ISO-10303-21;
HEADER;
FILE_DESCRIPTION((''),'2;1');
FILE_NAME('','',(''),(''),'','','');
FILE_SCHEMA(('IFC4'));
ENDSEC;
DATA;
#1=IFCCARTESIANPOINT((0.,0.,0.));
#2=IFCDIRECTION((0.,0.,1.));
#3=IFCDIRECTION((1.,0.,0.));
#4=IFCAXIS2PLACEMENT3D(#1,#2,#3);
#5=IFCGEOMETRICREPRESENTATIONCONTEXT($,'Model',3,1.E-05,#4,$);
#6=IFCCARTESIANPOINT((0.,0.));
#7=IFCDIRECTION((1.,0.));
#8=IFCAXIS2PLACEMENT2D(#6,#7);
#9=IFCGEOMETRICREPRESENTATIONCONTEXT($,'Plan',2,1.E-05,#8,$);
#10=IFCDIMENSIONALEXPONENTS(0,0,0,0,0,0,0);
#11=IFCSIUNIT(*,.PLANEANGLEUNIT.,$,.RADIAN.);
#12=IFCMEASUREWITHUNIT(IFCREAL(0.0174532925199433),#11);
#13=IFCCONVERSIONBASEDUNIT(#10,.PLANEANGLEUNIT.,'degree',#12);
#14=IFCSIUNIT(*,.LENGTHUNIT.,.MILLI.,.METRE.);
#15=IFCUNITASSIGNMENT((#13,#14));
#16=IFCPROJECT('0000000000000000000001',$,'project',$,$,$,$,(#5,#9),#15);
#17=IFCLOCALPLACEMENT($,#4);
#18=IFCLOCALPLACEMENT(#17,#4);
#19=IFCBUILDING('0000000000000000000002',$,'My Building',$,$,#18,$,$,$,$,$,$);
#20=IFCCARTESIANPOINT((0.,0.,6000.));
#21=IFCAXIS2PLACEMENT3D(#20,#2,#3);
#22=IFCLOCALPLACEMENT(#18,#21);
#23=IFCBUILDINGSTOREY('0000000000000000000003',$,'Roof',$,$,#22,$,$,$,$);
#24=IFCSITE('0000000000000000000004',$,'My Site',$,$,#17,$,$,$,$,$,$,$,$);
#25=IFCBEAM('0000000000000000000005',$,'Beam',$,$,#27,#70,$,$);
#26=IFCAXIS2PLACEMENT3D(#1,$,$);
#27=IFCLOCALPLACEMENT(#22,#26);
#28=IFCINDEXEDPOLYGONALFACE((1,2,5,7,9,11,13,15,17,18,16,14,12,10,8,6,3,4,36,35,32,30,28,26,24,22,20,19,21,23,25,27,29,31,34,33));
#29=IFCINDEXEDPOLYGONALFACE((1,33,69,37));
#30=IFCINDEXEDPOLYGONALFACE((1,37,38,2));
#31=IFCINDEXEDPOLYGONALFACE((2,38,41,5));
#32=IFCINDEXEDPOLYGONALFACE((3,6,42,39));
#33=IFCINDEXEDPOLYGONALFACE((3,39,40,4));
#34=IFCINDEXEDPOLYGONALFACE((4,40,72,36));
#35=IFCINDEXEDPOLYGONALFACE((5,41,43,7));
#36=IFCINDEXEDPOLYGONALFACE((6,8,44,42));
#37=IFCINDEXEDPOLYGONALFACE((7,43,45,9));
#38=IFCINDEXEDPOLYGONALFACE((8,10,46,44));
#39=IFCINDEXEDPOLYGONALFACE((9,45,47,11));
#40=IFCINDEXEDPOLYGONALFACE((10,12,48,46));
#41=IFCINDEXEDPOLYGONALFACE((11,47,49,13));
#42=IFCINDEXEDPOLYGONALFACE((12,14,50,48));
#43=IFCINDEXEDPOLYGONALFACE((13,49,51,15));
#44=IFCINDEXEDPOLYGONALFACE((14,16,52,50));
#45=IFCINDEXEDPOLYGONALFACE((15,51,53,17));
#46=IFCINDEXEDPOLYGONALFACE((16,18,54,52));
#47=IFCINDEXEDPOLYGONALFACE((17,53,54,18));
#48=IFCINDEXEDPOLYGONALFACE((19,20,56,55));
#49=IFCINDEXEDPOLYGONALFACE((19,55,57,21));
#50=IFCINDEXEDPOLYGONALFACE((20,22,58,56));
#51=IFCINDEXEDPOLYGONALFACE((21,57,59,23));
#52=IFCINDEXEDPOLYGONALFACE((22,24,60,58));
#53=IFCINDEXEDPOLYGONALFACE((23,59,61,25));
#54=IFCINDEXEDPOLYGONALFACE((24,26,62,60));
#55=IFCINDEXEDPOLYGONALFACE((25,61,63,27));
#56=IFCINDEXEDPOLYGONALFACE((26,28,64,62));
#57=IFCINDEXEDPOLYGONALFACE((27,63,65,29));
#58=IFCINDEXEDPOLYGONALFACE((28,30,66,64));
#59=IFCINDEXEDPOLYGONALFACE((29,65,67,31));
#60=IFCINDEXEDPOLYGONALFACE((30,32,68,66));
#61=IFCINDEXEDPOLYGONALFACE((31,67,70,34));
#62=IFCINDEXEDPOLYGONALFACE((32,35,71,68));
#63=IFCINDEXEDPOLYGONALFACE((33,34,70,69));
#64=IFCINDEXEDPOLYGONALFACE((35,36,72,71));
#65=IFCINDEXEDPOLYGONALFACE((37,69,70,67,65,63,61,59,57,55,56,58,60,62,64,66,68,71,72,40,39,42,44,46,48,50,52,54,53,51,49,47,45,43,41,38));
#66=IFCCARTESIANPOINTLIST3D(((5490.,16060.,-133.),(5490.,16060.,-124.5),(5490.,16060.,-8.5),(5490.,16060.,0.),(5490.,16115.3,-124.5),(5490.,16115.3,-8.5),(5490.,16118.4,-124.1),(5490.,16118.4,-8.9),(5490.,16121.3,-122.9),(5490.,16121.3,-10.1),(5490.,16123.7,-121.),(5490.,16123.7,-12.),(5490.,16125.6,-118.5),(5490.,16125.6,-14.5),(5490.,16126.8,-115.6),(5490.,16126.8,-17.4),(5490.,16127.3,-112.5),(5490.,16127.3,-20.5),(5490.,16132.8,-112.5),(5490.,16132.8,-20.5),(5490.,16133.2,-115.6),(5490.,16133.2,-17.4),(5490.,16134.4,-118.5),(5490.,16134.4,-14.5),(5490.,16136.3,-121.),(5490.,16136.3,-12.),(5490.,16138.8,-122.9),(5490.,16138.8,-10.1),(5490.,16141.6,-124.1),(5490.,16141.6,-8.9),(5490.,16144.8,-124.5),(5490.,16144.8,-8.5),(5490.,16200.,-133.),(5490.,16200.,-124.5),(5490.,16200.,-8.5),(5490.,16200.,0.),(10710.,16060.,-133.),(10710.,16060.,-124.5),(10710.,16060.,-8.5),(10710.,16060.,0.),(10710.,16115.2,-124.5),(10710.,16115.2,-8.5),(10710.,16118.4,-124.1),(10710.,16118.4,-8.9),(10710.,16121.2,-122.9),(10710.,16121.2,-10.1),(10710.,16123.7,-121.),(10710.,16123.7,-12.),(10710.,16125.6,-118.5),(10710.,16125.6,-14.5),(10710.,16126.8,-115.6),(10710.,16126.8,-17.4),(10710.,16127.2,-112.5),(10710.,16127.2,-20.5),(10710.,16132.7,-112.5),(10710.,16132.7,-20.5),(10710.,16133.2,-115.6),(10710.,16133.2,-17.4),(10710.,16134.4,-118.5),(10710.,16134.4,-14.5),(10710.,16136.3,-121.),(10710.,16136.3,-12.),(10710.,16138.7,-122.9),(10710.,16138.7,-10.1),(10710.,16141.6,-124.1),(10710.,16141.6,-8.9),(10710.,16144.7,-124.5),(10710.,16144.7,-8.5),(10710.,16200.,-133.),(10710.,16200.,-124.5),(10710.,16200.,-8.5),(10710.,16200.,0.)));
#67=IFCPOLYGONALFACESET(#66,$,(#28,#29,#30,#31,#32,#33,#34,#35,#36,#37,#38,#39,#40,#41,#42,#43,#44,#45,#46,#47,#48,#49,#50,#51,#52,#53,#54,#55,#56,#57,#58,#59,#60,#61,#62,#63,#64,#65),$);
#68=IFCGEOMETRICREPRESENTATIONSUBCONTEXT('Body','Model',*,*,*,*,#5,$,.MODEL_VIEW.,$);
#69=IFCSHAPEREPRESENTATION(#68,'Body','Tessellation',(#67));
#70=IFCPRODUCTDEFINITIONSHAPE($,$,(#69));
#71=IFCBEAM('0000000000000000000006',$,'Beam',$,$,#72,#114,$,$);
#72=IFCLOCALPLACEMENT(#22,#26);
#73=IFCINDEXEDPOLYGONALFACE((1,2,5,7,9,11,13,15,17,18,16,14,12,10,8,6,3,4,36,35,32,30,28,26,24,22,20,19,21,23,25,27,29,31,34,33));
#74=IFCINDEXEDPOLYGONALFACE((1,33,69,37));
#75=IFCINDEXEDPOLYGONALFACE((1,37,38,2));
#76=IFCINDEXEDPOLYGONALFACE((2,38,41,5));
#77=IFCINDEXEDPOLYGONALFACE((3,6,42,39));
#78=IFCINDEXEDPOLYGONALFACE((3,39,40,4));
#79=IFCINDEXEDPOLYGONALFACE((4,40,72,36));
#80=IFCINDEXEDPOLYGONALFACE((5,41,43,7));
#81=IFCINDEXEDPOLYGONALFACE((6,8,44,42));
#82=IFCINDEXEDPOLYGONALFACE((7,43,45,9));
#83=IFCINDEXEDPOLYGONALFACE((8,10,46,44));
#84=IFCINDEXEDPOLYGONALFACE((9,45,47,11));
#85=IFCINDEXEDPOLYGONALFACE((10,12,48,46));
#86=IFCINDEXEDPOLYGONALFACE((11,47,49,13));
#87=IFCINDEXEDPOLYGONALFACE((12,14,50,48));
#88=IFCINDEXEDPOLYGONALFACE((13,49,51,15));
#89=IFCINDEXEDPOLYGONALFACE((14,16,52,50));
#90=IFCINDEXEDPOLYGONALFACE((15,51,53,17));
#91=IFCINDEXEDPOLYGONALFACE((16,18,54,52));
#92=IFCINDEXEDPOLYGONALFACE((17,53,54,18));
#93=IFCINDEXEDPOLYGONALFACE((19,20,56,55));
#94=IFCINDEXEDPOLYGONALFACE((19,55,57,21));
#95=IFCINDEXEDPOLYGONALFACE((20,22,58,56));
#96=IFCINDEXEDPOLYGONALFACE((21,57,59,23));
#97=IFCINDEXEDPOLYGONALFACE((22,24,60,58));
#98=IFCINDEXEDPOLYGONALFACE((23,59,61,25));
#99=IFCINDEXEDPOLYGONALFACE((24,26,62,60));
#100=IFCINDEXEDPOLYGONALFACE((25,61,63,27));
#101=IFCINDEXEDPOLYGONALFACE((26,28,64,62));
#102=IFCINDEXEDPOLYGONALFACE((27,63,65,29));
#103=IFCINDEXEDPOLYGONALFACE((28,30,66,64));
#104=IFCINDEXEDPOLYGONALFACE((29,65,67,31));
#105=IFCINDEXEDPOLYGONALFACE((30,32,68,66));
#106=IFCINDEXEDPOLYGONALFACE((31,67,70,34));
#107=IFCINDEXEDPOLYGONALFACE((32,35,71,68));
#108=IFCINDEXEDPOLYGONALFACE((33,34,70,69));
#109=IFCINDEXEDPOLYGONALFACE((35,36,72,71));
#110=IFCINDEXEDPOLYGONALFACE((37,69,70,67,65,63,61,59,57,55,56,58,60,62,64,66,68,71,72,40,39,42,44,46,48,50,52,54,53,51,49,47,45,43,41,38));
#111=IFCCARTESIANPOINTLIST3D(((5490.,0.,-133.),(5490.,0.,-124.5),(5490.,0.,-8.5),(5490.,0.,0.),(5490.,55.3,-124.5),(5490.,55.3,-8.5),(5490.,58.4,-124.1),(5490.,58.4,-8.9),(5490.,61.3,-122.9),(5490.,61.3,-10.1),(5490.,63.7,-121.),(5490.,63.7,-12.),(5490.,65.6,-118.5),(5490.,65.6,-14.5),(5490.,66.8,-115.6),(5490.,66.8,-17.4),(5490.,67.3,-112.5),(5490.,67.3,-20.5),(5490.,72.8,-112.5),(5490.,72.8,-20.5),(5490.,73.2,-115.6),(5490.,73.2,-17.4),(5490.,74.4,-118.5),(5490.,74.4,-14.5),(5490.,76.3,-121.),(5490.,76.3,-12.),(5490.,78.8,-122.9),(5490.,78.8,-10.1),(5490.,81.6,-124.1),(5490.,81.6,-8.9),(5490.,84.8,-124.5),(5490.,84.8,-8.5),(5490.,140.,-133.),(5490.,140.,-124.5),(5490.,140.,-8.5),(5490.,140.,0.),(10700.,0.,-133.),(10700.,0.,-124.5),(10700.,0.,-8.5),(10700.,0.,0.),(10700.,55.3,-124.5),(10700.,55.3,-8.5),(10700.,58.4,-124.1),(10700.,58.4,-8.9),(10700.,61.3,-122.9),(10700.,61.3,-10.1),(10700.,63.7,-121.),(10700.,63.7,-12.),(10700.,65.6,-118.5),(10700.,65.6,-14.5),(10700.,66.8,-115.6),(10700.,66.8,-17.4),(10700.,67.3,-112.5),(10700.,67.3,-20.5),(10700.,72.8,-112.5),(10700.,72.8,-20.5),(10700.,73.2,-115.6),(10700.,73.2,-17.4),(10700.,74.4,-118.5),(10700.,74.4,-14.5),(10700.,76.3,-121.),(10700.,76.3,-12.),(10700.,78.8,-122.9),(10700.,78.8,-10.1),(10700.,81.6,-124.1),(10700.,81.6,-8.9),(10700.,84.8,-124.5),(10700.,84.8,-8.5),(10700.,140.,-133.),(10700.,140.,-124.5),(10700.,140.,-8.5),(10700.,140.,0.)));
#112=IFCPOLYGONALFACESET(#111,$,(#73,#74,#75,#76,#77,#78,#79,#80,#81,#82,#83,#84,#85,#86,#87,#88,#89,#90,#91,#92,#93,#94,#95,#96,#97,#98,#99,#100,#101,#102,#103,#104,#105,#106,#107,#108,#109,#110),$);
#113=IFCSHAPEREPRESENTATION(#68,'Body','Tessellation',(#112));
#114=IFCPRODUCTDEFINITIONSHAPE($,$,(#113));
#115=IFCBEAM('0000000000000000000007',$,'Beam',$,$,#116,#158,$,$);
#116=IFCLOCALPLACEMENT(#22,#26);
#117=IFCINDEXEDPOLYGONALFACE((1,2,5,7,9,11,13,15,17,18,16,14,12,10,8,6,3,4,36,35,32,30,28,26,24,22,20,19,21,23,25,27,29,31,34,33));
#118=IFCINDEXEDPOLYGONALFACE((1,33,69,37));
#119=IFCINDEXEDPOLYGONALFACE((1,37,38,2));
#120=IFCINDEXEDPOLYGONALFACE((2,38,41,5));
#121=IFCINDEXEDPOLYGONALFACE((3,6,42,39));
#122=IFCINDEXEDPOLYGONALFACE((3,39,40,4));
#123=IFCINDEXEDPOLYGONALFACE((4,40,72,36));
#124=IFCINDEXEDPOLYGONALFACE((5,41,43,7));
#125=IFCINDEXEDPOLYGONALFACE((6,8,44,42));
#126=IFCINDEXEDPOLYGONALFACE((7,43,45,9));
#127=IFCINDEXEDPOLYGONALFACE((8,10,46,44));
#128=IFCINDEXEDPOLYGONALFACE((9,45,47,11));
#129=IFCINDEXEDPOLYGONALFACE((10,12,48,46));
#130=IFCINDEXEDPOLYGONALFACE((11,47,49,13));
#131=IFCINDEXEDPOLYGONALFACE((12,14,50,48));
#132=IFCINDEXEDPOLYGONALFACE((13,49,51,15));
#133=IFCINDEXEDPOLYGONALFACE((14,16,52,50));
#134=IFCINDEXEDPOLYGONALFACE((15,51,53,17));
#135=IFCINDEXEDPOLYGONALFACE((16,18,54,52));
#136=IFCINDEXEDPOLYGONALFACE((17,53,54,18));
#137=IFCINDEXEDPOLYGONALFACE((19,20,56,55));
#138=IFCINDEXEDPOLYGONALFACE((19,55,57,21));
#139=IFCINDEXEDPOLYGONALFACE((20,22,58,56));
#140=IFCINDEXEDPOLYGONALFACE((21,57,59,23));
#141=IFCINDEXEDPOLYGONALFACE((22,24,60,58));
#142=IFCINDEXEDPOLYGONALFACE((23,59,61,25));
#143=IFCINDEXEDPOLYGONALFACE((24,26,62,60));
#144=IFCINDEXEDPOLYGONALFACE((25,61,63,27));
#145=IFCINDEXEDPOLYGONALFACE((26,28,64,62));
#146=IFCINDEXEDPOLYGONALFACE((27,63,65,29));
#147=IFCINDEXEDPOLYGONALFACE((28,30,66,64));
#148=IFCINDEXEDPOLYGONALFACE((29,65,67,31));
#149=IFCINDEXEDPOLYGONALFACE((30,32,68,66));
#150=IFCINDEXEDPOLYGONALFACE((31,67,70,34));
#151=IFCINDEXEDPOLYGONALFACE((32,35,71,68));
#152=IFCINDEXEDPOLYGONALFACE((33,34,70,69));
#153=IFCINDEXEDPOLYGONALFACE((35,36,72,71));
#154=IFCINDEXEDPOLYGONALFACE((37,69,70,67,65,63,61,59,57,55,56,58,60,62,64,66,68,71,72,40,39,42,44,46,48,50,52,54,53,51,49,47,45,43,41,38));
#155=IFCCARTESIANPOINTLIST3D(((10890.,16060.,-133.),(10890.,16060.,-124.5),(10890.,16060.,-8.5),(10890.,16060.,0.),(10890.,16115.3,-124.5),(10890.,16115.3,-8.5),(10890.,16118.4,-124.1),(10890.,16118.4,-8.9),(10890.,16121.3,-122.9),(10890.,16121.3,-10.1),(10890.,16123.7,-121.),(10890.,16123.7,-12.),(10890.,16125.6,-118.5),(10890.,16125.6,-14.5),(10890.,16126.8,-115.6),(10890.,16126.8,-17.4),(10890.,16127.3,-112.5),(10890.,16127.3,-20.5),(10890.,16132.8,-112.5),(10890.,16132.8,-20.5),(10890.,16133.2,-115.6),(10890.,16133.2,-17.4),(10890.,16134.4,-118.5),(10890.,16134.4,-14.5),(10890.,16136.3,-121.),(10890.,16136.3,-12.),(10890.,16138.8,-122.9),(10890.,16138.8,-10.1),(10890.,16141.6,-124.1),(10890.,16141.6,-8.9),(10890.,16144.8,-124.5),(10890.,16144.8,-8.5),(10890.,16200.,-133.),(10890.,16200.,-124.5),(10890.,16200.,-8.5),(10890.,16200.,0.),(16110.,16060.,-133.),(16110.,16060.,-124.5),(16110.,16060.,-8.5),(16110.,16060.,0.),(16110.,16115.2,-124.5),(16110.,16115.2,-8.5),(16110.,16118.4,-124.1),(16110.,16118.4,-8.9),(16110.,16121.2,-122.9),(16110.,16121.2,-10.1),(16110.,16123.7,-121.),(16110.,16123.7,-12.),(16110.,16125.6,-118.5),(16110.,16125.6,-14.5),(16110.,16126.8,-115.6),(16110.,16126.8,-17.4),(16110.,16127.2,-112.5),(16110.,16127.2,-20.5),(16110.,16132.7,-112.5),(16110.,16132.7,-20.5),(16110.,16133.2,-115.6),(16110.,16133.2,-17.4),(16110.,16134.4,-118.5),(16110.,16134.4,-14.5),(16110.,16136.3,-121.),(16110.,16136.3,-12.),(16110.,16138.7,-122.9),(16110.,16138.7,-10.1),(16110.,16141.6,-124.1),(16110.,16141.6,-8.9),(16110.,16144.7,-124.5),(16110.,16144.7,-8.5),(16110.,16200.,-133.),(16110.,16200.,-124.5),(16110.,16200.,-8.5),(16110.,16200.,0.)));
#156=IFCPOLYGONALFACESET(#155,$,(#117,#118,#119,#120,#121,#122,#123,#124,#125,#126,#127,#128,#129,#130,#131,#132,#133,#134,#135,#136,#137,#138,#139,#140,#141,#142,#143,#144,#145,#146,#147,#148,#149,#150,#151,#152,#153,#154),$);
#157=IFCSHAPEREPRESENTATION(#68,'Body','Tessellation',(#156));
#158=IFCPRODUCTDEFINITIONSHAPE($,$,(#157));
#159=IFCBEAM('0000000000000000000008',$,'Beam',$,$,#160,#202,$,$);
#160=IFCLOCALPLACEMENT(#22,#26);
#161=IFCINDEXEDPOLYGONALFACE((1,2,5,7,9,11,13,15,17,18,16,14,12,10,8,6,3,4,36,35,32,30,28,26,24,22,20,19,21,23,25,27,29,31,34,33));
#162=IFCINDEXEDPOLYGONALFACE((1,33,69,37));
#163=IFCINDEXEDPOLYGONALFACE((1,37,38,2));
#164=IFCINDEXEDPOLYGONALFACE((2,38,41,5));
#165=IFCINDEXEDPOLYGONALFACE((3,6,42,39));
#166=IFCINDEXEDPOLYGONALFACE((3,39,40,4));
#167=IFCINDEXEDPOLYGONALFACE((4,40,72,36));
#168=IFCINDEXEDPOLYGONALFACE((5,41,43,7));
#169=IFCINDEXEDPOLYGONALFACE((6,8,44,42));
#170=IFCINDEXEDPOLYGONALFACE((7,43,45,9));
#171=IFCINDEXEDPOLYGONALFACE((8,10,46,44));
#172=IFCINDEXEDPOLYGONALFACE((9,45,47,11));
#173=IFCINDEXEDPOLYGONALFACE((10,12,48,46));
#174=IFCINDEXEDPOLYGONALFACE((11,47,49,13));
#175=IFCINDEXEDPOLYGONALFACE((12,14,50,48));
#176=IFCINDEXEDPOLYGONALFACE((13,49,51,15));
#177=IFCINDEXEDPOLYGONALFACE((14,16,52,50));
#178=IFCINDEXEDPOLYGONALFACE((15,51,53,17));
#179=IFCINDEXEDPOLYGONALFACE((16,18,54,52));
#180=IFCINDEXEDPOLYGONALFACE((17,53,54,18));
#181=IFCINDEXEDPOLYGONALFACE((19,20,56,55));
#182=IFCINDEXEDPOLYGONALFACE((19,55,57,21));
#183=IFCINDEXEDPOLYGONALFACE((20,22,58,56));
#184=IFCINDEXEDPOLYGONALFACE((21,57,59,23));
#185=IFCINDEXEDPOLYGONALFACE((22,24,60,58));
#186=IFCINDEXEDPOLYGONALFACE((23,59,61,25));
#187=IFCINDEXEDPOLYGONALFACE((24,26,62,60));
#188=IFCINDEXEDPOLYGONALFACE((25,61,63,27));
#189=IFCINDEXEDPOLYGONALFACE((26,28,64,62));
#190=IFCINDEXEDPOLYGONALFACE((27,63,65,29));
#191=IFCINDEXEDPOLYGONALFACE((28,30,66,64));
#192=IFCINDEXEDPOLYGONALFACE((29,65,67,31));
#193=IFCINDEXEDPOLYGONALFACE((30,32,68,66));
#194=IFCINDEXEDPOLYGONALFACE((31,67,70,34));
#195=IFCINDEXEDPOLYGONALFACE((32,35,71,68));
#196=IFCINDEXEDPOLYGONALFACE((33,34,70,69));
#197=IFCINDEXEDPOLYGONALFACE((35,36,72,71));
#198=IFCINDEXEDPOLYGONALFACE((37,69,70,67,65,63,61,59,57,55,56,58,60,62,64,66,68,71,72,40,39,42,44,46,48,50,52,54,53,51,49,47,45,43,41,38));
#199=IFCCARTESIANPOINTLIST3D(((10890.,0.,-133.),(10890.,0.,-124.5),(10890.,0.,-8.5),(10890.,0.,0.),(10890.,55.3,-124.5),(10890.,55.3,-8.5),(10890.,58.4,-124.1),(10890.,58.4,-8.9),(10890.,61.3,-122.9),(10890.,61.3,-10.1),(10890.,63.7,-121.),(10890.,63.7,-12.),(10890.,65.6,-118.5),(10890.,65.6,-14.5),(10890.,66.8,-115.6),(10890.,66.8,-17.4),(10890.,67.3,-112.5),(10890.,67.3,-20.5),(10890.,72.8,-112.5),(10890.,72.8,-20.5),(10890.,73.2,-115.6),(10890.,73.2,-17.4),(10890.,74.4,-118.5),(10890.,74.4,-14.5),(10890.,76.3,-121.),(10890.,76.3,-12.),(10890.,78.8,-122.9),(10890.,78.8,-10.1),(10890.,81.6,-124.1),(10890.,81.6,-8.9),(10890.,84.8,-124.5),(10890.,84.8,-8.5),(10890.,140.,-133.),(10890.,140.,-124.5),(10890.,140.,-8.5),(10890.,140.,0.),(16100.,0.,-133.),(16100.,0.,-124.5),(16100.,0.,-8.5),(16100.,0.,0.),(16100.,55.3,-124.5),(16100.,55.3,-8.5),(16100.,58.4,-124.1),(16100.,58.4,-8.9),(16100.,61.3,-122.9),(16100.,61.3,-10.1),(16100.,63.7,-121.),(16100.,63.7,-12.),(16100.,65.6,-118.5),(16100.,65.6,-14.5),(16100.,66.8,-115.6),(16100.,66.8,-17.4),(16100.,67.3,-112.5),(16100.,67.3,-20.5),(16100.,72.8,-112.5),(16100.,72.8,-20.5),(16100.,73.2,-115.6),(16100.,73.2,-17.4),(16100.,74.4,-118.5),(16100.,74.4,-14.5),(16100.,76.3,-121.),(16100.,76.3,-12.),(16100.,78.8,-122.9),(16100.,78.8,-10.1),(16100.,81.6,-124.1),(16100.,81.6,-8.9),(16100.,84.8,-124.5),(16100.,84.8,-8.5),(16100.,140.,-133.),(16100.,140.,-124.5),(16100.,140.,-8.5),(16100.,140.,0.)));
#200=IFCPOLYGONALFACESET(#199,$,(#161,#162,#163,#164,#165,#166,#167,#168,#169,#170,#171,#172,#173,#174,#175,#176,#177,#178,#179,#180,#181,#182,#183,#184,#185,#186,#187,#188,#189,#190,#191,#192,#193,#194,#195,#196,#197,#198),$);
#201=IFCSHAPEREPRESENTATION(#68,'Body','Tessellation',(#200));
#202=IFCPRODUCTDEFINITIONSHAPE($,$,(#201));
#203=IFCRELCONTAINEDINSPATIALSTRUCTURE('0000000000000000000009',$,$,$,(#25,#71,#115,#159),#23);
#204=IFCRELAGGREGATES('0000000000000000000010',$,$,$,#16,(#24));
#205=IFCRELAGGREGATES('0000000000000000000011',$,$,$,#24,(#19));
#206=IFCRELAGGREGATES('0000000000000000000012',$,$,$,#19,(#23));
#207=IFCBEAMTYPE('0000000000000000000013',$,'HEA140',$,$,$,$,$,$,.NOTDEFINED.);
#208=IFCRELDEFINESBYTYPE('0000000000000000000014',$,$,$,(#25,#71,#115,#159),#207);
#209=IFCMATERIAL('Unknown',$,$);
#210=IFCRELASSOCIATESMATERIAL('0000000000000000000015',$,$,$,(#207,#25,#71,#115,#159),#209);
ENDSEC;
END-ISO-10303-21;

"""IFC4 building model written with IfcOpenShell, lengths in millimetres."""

from ifc_helpers import new_model, entity, si_unit, converted_unit, frame, origin_with_axes, origin_2d_with_axis, place, context, subcontext, project, spatial, i_section, extrude, material, material_profile, profile_set, profile_usage, type_object, element, save


model = new_model("IFC4")

# Units and contexts
model_context = context("Model", 3, precision=1e-05, world=origin_with_axes())
plan_context = context("Plan", 2, precision=1e-05, world=origin_2d_with_axis())
body_context = subcontext(model_context, "Body", "Model", "MODEL_VIEW")
ifc_project = project(units=[converted_unit("PLANEANGLEUNIT", "degree", entity("IfcReal", 0.0174532925199433), si_unit("PLANEANGLEUNIT", "RADIAN"), dimensions=[0, 0, 0, 0, 0, 0, 0]), si_unit("LENGTHUNIT", "METRE", prefix="MILLI")], contexts=[model_context, plan_context])

# Site, building, storey
site_placement = place(None, origin_with_axes())
site = spatial("IfcSite", under=ifc_project, at=site_placement, Name="My Site")
building_placement = place(site_placement, origin_with_axes())
building = spatial("IfcBuilding", under=site, at=building_placement, Name="My Building")
storey_placement = place(building_placement, frame((0.0, 0.0, 6000.0), z_axis=(0.0, 0.0, 1.0), x_axis=(1.0, 0.0, 0.0)))
storey = spatial("IfcBuildingStorey", under=building, at=storey_placement, Name="Roof")

# Beams
ifc_material = material(Name="Unknown")
ifc_material_profile_1 = material_profile(ifc_material, i_section(OverallWidth=140.0, OverallDepth=133.0, WebThickness=5.5, FlangeThickness=8.5, FilletRadius=12.0))
ifc_profile_set_1 = profile_set([ifc_material_profile_1])
ifc_profile_usage_1 = profile_usage(ifc_profile_set_1, cardinal=7)
beam_type_1 = type_object("IfcBeamType", Name="HEA140", PredefinedType="NOTDEFINED", material=ifc_profile_set_1)
beam_1_placement = place(storey_placement, frame((5490.0, 16200.0, 0.0), z_axis=(1.0, 0.0, 0.0), x_axis=(0.0, 1.0, 0.0)))
element("IfcBeam", 1, at=beam_1_placement, inside=storey, type_object=beam_type_1, material=ifc_profile_usage_1, Name="Beam", context=body_context, shape_type="SweptSolid", body=[
    extrude(i_section(OverallWidth=140.0, OverallDepth=133.0, WebThickness=5.5, FlangeThickness=8.5, FilletRadius=12.0), frame((-70.0, -66.5, 0.0), z_axis=(0.0, 0.0, 1.0), x_axis=(1.0, 0.0, 0.0)), (0.0, 0.0, 1.0), 5220.0),
])
ifc_profile_usage_2 = profile_usage(ifc_profile_set_1, cardinal=7)
beam_2_placement = place(storey_placement, frame((10700.0, 0.0, 0.0), z_axis=(-1.0, 0.0, 0.0), x_axis=(0.0, -1.0, 0.0)))
element("IfcBeam", 2, at=beam_2_placement, inside=storey, type_object=beam_type_1, material=ifc_profile_usage_2, Name="Beam", context=body_context, shape_type="SweptSolid", body=[
    extrude(i_section(OverallWidth=140.0, OverallDepth=133.0, WebThickness=5.5, FlangeThickness=8.5, FilletRadius=12.0), frame((-70.0, -66.5, 0.0), z_axis=(0.0, 0.0, 1.0), x_axis=(1.0, 0.0, 0.0)), (0.0, 0.0, 1.0), 5210.0),
])
ifc_profile_usage_3 = profile_usage(ifc_profile_set_1, cardinal=7)
beam_3_placement = place(storey_placement, frame((10890.0, 16200.0, 0.0), z_axis=(1.0, 0.0, 0.0), x_axis=(0.0, 1.0, 0.0)))
element("IfcBeam", 3, at=beam_3_placement, inside=storey, type_object=beam_type_1, material=ifc_profile_usage_3, Name="Beam", context=body_context, shape_type="SweptSolid", body=[
    extrude(i_section(OverallWidth=140.0, OverallDepth=133.0, WebThickness=5.5, FlangeThickness=8.5, FilletRadius=12.0), frame((-70.0, -66.5, 0.0), z_axis=(0.0, 0.0, 1.0), x_axis=(1.0, 0.0, 0.0)), (0.0, 0.0, 1.0), 5220.0),
])
ifc_profile_usage_4 = profile_usage(ifc_profile_set_1, cardinal=7)
beam_4_placement = place(storey_placement, frame((16100.0, 0.0, 0.0), z_axis=(-1.0, 0.0, 0.0), x_axis=(0.0, -1.0, 0.0)))
element("IfcBeam", 4, at=beam_4_placement, inside=storey, type_object=beam_type_1, material=ifc_profile_usage_4, Name="Beam", context=body_context, shape_type="SweptSolid", body=[
    extrude(i_section(OverallWidth=140.0, OverallDepth=133.0, WebThickness=5.5, FlangeThickness=8.5, FilletRadius=12.0), frame((-70.0, -66.5, 0.0), z_axis=(0.0, 0.0, 1.0), x_axis=(1.0, 0.0, 0.0)), (0.0, 0.0, 1.0), 5210.0),
])

save(model, "model.ifc")
